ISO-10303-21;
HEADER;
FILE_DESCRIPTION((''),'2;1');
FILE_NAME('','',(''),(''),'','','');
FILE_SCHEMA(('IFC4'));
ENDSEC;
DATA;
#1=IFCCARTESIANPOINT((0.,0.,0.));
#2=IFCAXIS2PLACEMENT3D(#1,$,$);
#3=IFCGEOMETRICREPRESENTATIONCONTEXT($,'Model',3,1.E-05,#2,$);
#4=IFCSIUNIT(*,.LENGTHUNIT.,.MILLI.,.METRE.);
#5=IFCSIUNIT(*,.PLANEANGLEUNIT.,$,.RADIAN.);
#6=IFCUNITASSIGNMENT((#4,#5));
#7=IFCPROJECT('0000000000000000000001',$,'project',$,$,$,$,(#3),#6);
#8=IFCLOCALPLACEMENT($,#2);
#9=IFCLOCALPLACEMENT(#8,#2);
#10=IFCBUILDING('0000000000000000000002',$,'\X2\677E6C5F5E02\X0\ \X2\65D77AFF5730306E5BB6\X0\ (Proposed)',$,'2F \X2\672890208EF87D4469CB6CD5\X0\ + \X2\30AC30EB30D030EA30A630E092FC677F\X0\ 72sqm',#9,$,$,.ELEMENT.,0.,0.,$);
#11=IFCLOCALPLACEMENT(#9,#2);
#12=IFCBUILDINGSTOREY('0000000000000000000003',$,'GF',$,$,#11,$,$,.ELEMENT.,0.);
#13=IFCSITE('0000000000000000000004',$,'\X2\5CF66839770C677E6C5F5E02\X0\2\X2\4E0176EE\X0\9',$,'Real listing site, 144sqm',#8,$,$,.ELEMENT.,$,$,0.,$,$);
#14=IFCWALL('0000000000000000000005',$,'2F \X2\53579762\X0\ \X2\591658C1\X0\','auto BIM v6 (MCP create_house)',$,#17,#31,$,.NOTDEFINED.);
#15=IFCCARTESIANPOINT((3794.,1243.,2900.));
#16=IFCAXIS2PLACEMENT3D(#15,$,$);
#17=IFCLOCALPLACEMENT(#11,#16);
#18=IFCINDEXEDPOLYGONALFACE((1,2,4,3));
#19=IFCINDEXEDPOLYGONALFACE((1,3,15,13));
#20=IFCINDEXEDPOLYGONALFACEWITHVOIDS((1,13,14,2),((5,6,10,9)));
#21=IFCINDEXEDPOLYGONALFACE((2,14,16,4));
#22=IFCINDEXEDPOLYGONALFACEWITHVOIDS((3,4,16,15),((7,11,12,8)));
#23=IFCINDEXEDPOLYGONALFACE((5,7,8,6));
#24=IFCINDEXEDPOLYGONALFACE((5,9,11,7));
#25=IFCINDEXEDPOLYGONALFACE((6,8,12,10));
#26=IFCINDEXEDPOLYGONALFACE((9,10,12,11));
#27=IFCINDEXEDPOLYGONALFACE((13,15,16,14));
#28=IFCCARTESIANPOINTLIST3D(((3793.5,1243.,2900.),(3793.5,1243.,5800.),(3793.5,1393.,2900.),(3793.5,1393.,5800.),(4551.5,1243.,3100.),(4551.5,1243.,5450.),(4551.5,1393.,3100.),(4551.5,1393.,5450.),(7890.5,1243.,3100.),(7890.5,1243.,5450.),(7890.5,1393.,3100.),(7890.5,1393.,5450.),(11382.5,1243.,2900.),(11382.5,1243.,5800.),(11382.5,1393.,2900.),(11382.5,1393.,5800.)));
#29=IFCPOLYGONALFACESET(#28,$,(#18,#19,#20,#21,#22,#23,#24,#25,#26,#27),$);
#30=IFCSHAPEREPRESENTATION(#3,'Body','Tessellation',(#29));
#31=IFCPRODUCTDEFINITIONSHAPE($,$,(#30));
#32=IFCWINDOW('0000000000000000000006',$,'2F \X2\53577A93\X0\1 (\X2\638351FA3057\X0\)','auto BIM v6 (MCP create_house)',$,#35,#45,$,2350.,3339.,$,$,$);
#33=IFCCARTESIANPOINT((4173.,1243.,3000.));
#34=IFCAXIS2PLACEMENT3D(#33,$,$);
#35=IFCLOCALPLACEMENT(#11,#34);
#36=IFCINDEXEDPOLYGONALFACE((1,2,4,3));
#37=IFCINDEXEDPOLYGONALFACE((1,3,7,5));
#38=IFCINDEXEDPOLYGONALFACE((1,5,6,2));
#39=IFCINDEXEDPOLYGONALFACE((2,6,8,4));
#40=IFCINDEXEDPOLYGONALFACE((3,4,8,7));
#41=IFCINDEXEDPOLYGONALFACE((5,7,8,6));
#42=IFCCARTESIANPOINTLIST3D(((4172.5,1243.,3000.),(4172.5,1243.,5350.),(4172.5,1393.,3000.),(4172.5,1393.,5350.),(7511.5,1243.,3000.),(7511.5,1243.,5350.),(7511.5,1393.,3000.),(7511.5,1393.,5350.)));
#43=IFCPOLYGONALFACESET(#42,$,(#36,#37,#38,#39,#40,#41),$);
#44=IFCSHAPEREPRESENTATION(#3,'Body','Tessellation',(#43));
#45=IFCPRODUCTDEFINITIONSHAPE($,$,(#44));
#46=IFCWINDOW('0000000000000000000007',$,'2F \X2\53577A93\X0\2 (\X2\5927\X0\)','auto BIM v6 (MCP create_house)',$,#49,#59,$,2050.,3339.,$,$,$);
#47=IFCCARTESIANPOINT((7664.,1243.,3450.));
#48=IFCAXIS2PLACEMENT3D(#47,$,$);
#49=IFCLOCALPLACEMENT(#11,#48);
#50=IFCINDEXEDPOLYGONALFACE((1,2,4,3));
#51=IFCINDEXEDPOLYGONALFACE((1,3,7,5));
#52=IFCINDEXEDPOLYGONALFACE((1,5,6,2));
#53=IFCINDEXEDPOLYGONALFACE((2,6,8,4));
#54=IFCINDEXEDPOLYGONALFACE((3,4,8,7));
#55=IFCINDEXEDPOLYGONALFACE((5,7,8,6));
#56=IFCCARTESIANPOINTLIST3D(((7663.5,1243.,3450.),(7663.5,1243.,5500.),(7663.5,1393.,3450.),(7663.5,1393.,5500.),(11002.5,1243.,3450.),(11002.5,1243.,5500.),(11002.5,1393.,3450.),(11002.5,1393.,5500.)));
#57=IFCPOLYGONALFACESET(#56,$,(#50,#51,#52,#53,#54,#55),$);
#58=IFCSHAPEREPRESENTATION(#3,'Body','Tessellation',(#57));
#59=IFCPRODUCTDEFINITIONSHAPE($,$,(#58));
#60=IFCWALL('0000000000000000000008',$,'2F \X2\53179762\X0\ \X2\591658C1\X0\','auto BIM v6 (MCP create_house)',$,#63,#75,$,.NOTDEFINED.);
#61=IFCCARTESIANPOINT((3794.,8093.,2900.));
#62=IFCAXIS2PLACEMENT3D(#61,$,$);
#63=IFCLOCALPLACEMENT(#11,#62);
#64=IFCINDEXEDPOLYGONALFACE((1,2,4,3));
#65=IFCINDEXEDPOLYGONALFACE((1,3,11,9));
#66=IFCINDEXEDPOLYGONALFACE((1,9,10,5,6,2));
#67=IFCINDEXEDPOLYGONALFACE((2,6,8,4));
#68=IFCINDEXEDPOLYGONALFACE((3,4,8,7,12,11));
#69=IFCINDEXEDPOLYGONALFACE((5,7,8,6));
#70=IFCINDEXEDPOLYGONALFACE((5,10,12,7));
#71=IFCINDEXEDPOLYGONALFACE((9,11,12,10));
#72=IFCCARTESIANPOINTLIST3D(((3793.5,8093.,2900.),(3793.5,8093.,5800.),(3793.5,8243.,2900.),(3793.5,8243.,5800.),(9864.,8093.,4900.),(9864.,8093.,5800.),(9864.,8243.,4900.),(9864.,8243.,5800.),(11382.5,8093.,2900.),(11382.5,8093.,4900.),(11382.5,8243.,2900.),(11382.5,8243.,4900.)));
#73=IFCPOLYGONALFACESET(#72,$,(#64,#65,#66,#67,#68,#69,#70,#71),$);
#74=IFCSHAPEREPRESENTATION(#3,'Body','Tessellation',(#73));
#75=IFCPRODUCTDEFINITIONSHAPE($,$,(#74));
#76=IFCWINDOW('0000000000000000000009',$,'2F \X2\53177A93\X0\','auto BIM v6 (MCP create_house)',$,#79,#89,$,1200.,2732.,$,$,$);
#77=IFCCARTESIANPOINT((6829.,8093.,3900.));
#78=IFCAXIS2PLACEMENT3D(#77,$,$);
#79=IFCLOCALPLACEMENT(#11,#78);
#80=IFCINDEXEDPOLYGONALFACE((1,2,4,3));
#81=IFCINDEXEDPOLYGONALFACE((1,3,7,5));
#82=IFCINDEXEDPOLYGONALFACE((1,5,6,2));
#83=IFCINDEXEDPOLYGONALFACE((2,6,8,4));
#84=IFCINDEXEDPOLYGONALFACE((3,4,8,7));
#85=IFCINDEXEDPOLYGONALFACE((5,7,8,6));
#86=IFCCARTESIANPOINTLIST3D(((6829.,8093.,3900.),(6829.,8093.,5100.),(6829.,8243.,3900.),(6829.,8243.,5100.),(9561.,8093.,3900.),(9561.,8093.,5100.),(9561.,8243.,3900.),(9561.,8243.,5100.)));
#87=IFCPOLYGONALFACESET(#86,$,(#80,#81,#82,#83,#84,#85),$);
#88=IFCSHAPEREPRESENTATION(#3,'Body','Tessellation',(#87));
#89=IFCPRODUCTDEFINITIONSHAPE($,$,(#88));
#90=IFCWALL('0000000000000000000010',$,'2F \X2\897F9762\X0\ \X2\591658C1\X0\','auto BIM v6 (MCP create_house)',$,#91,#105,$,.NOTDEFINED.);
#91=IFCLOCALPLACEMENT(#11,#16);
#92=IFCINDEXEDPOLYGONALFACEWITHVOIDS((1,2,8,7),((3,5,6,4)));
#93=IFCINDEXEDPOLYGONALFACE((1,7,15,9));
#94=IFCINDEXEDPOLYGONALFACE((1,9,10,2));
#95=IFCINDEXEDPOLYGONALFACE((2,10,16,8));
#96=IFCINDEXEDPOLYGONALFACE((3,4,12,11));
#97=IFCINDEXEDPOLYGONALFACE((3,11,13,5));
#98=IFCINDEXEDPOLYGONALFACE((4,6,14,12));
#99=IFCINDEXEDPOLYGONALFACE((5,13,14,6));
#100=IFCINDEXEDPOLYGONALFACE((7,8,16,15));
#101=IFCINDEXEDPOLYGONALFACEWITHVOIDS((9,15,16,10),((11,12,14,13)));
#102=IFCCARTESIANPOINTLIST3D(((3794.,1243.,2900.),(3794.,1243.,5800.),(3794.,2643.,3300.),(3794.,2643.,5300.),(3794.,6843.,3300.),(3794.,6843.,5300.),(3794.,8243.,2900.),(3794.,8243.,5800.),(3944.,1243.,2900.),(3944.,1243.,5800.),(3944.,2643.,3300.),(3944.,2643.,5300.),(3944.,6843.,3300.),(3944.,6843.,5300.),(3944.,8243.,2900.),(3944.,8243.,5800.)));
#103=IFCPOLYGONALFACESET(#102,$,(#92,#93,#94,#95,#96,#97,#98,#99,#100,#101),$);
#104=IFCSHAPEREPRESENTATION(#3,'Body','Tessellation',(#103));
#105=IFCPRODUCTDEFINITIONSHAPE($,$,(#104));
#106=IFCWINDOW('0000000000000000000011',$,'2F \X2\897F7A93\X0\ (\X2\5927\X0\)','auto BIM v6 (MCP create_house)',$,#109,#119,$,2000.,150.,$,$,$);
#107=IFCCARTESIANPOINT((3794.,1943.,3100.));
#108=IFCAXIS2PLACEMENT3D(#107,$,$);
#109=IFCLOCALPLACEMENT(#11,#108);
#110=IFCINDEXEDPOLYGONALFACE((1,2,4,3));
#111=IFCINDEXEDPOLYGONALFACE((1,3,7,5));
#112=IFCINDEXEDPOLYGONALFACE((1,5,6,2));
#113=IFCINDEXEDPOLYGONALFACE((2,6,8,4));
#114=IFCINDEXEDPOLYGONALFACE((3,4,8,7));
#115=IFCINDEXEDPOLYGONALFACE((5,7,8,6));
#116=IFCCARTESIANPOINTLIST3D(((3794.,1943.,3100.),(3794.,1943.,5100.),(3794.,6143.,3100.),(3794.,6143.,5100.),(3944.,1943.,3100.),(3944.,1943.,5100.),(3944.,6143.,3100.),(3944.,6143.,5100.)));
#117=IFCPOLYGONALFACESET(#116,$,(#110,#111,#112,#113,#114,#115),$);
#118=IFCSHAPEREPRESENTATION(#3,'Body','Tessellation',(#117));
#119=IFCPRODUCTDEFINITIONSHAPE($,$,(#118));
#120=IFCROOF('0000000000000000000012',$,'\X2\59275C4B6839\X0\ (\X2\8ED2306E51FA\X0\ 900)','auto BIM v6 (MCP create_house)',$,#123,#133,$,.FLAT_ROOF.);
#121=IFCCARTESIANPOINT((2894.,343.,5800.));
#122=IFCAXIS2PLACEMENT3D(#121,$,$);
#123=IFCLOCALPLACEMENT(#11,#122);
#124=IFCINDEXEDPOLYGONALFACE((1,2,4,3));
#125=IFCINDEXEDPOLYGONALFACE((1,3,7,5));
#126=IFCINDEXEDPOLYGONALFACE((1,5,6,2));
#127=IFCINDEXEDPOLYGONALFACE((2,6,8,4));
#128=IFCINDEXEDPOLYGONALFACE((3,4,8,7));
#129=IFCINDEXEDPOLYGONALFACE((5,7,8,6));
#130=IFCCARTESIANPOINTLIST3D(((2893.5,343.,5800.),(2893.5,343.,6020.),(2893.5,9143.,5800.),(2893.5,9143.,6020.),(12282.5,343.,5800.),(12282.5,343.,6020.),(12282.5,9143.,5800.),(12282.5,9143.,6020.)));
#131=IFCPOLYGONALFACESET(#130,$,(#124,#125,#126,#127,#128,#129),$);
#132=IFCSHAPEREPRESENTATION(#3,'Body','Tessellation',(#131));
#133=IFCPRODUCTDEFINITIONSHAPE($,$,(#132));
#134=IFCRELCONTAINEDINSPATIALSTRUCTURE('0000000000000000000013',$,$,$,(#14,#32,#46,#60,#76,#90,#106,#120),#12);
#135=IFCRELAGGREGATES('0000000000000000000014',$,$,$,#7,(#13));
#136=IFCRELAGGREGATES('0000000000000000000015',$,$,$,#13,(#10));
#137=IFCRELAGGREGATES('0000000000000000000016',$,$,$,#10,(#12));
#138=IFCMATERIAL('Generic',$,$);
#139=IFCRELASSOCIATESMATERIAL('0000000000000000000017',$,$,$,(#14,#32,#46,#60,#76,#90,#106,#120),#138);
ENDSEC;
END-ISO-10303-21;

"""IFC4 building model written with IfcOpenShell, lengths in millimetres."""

from ifc_helpers import new_model, si_unit, frame, frame_2d, origin, place, context, project, spatial, rectangle, extrude, material, element, fill, save


model = new_model("IFC4")

# Units and contexts
model_context = context("Model", 3, precision=1e-05, world=origin())
ifc_project = project(units=[si_unit("LENGTHUNIT", "METRE", prefix="MILLI"), si_unit("PLANEANGLEUNIT", "RADIAN")], contexts=[model_context])

# Site, building, storey
site_placement = place(None, origin())
site = spatial("IfcSite", under=ifc_project, at=site_placement, Name="島根県松江市2丁目9", ObjectType="Real listing site, 144sqm", CompositionType="ELEMENT", RefElevation=0.0)
building_placement = place(site_placement, origin())
building = spatial("IfcBuilding", under=site, at=building_placement, Name="松江市 旗竿地の家 (Proposed)", ObjectType="2F 木造軸組構法 + ガルバリウム鋼板 72sqm", CompositionType="ELEMENT", ElevationOfRefHeight=0.0, ElevationOfTerrain=0.0)
storey_placement = place(building_placement, origin())
storey = spatial("IfcBuildingStorey", under=building, at=storey_placement, Name="GF", CompositionType="ELEMENT", Elevation=0.0)

# Shared definitions
ifc_material = material(Name="Generic")

# Wall, openings, windows
wall_1_placement = place(storey_placement, frame((3794.0, 1243.0, 2900.0)))
wall_1 = element("IfcWall", 1, at=wall_1_placement, inside=storey, material=ifc_material, Name="2F 南面 外壁", Description="auto BIM v6 (MCP create_house)", PredefinedType="NOTDEFINED", context=model_context, shape_type="SweptSolid", body=[
    extrude(rectangle(XDim=7589.0, YDim=150.0, at=frame_2d((3794.0, 75.0))), frame((3794.0, 1243.0, 2900.0)), (0.0, 0.0, 1.0), 2900.0),
])
opening_1_placement = place(storey_placement, frame((4173.0, 1243.0, 3000.0)))
opening_1 = element("IfcOpeningElement", 2, at=opening_1_placement, cuts=wall_1, PredefinedType="NOTDEFINED", context=model_context, shape_type="SweptSolid", body=[
    extrude(rectangle(XDim=3339.0, YDim=150.0, at=frame_2d((1669.0, 75.0))), frame((4173.0, 1243.0, 3000.0)), (0.0, 0.0, 1.0), 2350.0),
])
opening_2_placement = place(storey_placement, frame((7664.0, 1243.0, 3450.0)))
opening_2 = element("IfcOpeningElement", 3, at=opening_2_placement, cuts=wall_1, PredefinedType="NOTDEFINED", context=model_context, shape_type="SweptSolid", body=[
    extrude(rectangle(XDim=3339.0, YDim=150.0, at=frame_2d((1669.0, 75.0))), frame((7664.0, 1243.0, 3450.0)), (0.0, 0.0, 1.0), 2050.0),
])
window_1_placement = place(storey_placement, frame((4173.0, 1243.0, 3000.0)))
window_1 = element("IfcWindow", 4, at=window_1_placement, inside=storey, material=ifc_material, Name="2F 南窓1 (掃出し)", Description="auto BIM v6 (MCP create_house)", OverallHeight=2350.0, OverallWidth=3339.0, context=model_context, shape_type="SweptSolid", body=[
    extrude(rectangle(XDim=3339.0, YDim=150.0, at=frame_2d((1669.0, 75.0))), frame((4173.0, 1243.0, 3000.0)), (0.0, 0.0, 1.0), 2350.0),
])
fill(opening_1, window_1)
window_2_placement = place(storey_placement, frame((7664.0, 1243.0, 3450.0)))
window_2 = element("IfcWindow", 5, at=window_2_placement, inside=storey, material=ifc_material, Name="2F 南窓2 (大)", Description="auto BIM v6 (MCP create_house)", OverallHeight=2050.0, OverallWidth=3339.0, context=model_context, shape_type="SweptSolid", body=[
    extrude(rectangle(XDim=3339.0, YDim=150.0, at=frame_2d((1669.0, 75.0))), frame((7664.0, 1243.0, 3450.0)), (0.0, 0.0, 1.0), 2050.0),
])
fill(opening_2, window_2)

# Walls, openings, windows
wall_2_placement = place(storey_placement, frame((3794.0, 8093.0, 2900.0)))
wall_2 = element("IfcWall", 6, at=wall_2_placement, inside=storey, material=ifc_material, Name="2F 北面 外壁", Description="auto BIM v6 (MCP create_house)", PredefinedType="NOTDEFINED", context=model_context, shape_type="SweptSolid", body=[
    extrude(rectangle(XDim=7589.0, YDim=150.0, at=frame_2d((3794.0, 75.0))), frame((3794.0, 8093.0, 2900.0)), (0.0, 0.0, 1.0), 2900.0),
])
opening_3_placement = place(storey_placement, frame((6829.0, 8093.0, 3900.0)))
opening_3 = element("IfcOpeningElement", 7, at=opening_3_placement, cuts=wall_2, PredefinedType="NOTDEFINED", context=model_context, shape_type="SweptSolid", body=[
    extrude(rectangle(XDim=2732.0, YDim=150.0, at=frame_2d((1366.0, 75.0))), frame((6829.0, 8093.0, 3900.0)), (0.0, 0.0, 1.0), 1200.0),
])
window_3_placement = place(storey_placement, frame((6829.0, 8093.0, 3900.0)))
window_3 = element("IfcWindow", 8, at=window_3_placement, inside=storey, material=ifc_material, Name="2F 北窓", Description="auto BIM v6 (MCP create_house)", OverallHeight=1200.0, OverallWidth=2732.0, context=model_context, shape_type="SweptSolid", body=[
    extrude(rectangle(XDim=2732.0, YDim=150.0, at=frame_2d((1366.0, 75.0))), frame((6829.0, 8093.0, 3900.0)), (0.0, 0.0, 1.0), 1200.0),
])
fill(opening_3, window_3)
wall_3_placement = place(storey_placement, frame((3794.0, 1243.0, 2900.0)))
wall_3 = element("IfcWall", 9, at=wall_3_placement, inside=storey, material=ifc_material, Name="2F 西面 外壁", Description="auto BIM v6 (MCP create_house)", PredefinedType="NOTDEFINED", context=model_context, shape_type="SweptSolid", body=[
    extrude(rectangle(XDim=150.0, YDim=7000.0, at=frame_2d((75.0, 3500.0))), frame((3794.0, 1243.0, 2900.0)), (0.0, 0.0, 1.0), 2900.0),
])
opening_4_placement = place(storey_placement, frame((3794.0, 1943.0, 3100.0)))
opening_4 = element("IfcOpeningElement", 10, at=opening_4_placement, cuts=wall_3, PredefinedType="NOTDEFINED", context=model_context, shape_type="SweptSolid", body=[
    extrude(rectangle(XDim=150.0, YDim=4200.0, at=frame_2d((75.0, 2100.0))), frame((3794.0, 1943.0, 3100.0)), (0.0, 0.0, 1.0), 2000.0),
])
window_4_placement = place(storey_placement, frame((3794.0, 1943.0, 3100.0)))
window_4 = element("IfcWindow", 11, at=window_4_placement, inside=storey, material=ifc_material, Name="2F 西窓 (大)", Description="auto BIM v6 (MCP create_house)", OverallHeight=2000.0, OverallWidth=150.0, context=model_context, shape_type="SweptSolid", body=[
    extrude(rectangle(XDim=150.0, YDim=4200.0, at=frame_2d((75.0, 2100.0))), frame((3794.0, 1943.0, 3100.0)), (0.0, 0.0, 1.0), 2000.0),
])
fill(opening_4, window_4)

# Roof
roof_placement = place(storey_placement, frame((2894.0, 343.0, 5800.0)))
element("IfcRoof", 12, at=roof_placement, inside=storey, material=ifc_material, Name="大屋根 (軒の出 900)", Description="auto BIM v6 (MCP create_house)", PredefinedType="FLAT_ROOF", context=model_context, shape_type="SweptSolid", body=[
    extrude(rectangle(XDim=9389.0, YDim=8800.0, at=frame_2d((4694.0, 4400.0))), frame((2894.0, 343.0, 5800.0)), (0.0, 0.0, 1.0), 220.0),
])

save(model, "model.ifc")
